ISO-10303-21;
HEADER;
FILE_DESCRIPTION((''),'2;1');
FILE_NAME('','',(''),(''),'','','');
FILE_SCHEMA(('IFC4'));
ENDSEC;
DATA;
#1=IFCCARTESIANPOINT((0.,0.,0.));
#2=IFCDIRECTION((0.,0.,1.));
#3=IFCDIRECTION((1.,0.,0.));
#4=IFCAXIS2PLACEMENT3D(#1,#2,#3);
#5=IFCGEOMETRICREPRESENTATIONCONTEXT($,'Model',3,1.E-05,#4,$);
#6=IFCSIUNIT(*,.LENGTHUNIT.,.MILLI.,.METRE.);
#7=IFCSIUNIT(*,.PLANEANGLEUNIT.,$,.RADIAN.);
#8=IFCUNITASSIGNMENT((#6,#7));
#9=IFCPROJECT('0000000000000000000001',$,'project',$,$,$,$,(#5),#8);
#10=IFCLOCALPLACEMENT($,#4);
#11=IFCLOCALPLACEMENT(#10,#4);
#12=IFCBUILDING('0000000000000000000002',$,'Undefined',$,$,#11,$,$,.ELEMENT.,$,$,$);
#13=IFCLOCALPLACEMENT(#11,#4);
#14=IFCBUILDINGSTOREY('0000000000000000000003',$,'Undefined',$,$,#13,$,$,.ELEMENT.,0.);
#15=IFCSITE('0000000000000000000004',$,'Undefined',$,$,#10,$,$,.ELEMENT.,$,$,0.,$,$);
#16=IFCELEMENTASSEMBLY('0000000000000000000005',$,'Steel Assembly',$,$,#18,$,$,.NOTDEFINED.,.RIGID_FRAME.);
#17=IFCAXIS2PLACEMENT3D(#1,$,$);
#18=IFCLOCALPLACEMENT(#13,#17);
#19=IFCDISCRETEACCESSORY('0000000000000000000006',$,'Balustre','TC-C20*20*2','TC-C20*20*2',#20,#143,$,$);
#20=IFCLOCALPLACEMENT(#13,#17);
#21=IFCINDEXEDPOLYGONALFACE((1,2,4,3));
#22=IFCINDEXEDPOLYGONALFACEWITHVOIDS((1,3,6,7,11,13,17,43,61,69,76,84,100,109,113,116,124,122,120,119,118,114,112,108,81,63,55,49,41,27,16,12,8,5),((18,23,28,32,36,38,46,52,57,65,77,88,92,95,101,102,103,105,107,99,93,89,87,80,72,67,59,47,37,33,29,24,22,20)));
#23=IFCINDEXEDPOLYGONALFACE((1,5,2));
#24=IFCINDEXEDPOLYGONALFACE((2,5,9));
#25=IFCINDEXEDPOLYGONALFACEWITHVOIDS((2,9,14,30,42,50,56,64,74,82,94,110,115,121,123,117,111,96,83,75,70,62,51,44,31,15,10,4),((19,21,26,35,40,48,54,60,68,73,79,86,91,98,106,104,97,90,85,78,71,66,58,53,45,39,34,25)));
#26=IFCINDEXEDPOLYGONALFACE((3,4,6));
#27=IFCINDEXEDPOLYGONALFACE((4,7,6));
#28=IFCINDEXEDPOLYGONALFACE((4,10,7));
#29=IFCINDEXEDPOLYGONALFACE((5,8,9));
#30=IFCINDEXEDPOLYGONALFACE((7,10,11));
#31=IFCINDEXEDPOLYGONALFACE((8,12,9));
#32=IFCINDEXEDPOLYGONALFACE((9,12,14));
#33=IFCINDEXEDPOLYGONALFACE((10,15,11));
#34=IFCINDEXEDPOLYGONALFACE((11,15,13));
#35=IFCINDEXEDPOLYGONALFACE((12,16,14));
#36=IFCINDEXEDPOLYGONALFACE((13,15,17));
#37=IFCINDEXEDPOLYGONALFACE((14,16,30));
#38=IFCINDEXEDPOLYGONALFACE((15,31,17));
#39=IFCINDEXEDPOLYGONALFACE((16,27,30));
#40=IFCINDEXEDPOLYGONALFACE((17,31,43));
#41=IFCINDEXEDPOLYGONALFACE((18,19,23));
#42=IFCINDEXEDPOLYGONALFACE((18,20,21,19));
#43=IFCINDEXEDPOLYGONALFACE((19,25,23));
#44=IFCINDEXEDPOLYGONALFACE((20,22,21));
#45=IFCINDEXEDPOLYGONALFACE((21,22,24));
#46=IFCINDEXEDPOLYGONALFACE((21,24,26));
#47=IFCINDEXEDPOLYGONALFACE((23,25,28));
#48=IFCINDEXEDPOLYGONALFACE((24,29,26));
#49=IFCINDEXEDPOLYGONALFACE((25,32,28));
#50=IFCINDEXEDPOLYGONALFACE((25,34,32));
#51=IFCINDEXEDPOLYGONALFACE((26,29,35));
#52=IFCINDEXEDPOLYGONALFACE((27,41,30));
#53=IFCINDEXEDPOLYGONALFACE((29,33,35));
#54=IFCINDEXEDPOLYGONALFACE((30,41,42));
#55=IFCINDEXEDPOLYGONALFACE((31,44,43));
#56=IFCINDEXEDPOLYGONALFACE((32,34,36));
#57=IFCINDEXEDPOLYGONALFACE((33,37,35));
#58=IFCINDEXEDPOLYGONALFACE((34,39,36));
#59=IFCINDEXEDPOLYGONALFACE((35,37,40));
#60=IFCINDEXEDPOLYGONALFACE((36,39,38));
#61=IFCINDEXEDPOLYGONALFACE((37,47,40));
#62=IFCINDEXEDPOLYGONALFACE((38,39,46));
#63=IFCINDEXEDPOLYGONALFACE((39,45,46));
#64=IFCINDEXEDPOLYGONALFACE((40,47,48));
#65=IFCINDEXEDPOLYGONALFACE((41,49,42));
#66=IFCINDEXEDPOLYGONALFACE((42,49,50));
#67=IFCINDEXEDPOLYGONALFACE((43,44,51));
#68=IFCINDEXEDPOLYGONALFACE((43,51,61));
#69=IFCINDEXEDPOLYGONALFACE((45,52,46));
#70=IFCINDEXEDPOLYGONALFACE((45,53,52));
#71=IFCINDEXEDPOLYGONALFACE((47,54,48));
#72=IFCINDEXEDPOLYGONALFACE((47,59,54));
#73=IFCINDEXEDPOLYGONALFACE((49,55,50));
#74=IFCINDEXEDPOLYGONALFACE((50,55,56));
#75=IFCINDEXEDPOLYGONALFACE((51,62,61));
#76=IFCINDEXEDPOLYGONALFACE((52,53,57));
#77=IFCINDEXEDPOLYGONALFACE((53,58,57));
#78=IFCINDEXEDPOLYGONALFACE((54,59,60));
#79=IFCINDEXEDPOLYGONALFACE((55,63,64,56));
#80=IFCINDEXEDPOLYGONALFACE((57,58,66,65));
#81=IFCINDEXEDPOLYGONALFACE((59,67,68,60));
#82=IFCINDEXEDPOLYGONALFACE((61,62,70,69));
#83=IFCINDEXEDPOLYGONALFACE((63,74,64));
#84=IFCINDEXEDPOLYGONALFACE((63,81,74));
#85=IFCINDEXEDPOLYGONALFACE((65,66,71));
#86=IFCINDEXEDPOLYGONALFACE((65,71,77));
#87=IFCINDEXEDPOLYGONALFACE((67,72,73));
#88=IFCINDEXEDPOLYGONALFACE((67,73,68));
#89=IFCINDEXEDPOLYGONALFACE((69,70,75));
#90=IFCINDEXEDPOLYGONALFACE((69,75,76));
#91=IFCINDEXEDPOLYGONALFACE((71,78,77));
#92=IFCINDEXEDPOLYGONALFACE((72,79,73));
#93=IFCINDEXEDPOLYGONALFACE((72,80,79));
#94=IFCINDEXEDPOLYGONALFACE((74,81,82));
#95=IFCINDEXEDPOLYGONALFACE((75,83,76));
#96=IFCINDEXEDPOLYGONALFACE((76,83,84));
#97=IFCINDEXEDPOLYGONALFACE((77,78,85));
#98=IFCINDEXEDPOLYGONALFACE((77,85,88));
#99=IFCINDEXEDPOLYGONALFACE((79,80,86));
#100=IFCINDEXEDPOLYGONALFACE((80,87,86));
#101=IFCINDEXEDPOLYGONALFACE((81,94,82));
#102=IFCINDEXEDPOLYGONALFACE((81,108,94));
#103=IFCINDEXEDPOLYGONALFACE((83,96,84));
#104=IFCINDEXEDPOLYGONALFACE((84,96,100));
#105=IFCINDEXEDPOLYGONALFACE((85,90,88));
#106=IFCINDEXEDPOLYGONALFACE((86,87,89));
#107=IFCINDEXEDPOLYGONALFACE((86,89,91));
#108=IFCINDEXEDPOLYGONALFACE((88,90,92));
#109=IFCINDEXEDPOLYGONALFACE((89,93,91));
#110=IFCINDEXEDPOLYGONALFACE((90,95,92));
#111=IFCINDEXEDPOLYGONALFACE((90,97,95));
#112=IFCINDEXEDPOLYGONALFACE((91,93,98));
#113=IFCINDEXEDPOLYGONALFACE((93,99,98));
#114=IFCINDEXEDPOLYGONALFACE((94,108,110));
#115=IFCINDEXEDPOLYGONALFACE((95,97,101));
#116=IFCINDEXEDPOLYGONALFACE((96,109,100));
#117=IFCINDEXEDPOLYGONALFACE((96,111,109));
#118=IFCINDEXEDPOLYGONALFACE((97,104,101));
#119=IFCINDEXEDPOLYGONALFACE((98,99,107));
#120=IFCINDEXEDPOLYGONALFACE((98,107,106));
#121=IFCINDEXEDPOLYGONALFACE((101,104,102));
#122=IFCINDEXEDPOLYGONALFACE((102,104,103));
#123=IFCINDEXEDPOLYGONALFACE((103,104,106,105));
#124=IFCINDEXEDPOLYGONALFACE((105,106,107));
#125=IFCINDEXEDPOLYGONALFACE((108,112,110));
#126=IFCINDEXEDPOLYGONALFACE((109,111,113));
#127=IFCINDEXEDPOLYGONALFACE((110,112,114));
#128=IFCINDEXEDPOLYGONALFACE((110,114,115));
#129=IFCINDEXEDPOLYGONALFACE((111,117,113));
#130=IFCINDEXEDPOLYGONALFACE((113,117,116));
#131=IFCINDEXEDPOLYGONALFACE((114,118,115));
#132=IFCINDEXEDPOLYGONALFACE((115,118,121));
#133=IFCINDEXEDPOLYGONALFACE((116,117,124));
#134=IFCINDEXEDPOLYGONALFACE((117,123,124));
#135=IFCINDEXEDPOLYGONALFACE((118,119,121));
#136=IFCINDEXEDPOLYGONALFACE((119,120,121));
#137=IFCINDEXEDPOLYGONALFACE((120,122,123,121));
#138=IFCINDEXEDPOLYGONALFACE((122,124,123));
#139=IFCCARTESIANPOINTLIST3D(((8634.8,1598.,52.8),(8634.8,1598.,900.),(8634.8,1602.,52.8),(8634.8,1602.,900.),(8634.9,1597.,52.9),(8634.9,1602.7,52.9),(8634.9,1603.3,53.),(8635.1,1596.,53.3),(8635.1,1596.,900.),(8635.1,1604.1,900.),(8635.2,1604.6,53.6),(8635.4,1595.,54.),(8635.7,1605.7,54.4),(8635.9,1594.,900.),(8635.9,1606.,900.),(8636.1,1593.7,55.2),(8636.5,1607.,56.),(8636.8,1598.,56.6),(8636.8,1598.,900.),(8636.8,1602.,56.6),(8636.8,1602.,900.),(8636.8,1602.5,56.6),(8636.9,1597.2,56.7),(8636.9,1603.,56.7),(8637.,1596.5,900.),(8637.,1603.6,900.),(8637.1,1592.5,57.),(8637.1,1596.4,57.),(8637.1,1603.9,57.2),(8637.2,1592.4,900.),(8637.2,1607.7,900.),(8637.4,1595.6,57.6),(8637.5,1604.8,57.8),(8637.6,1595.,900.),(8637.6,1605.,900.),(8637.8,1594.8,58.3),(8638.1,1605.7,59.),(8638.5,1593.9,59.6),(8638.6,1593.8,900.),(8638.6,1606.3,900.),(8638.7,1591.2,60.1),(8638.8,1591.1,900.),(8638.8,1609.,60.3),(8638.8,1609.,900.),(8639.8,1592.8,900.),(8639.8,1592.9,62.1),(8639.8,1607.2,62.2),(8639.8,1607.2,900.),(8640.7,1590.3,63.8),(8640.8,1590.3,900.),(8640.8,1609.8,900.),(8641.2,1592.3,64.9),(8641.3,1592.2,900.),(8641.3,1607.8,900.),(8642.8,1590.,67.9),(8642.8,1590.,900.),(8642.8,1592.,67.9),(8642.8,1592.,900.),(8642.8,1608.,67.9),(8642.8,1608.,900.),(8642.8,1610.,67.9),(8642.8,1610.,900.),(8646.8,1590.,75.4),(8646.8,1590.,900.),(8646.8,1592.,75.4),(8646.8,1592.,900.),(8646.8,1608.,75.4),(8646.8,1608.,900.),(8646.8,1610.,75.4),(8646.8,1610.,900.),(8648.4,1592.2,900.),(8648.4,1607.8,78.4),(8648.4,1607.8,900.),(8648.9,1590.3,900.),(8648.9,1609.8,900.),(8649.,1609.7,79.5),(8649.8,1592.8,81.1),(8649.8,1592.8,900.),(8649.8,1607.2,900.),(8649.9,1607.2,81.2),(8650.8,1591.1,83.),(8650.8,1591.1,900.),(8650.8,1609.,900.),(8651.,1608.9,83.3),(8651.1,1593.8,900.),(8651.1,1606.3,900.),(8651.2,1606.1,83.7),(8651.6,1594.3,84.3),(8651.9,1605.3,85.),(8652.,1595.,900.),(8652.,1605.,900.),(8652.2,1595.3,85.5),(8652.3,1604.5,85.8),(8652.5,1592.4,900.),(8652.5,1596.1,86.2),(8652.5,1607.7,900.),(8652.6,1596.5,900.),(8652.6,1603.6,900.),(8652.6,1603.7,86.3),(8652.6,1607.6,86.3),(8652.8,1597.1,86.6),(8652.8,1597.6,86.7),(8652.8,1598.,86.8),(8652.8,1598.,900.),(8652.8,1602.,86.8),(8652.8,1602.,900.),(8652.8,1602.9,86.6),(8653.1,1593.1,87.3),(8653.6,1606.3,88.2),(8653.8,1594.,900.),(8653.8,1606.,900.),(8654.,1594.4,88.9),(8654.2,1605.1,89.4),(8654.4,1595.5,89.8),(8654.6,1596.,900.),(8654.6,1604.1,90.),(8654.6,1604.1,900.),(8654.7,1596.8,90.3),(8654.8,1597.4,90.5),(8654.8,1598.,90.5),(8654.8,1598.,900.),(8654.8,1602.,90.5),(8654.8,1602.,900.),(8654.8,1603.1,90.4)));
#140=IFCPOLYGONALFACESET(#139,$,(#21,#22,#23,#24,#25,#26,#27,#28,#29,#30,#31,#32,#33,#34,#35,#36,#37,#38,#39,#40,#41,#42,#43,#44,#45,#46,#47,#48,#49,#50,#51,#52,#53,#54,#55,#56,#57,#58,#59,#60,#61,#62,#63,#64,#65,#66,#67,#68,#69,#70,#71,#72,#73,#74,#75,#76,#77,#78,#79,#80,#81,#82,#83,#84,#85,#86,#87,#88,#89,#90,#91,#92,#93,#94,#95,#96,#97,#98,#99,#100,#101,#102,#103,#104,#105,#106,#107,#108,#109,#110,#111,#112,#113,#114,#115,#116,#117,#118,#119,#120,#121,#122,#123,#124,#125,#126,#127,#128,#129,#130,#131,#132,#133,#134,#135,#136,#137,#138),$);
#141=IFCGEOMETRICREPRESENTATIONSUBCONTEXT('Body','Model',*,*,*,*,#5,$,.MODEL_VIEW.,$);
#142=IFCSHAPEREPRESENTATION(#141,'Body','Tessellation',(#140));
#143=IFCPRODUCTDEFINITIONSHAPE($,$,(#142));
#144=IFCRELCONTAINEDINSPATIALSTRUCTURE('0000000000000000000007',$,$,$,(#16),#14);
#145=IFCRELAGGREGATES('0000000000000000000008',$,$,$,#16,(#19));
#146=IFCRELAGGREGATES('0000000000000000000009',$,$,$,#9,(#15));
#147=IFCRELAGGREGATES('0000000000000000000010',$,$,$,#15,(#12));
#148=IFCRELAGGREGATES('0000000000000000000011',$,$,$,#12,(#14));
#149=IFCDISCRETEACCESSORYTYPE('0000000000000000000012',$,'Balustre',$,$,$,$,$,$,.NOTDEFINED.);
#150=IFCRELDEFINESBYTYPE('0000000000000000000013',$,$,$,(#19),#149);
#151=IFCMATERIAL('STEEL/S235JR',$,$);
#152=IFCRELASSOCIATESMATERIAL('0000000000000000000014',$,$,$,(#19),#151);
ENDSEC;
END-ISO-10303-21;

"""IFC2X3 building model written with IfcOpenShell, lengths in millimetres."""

from ifc_helpers import new_model, si_unit, frame, origin_with_axes, origin_2d_with_axis, place, context, subcontext, project, spatial, hollow_rectangle, extrude, clip, halfspace, material, type_object, element, aggregate, save


model = new_model("IFC2X3")

# Units and contexts
model_context = context("Model", 3, precision=1e-05, world=origin_with_axes())
body_context = subcontext(model_context, "Body", "Model", "MODEL_VIEW")
ifc_project = project(units=[si_unit("LENGTHUNIT", "METRE", prefix="MILLI"), si_unit("PLANEANGLEUNIT", "RADIAN")], contexts=[model_context])

# Site, building, storey
site_placement = place(None, origin_with_axes())
site = spatial("IfcSite", under=ifc_project, at=site_placement, Name="Undefined", CompositionType="ELEMENT", RefElevation=0.0)
building_placement = place(site_placement, origin_with_axes())
building = spatial("IfcBuilding", under=site, at=building_placement, Name="Undefined", CompositionType="ELEMENT")
storey_placement = place(building_placement, origin_with_axes())
storey = spatial("IfcBuildingStorey", under=building, at=storey_placement, Name="Undefined", CompositionType="ELEMENT", Elevation=0.0)

# Shared definitions
ifc_material = material(Name="STEEL/S235JR")

# Element assembly, discrete accessory
discrete_accessory_type_1 = type_object("IfcDiscreteAccessoryType", Name="Balustre")
assembly_1_placement = place(storey_placement, origin_with_axes())
assembly_1 = element("IfcElementAssembly", 1, at=assembly_1_placement, inside=storey, Name="Steel Assembly", AssemblyPlace="NOTDEFINED", PredefinedType="RIGID_FRAME")
discrete_accessory_1_placement = place(assembly_1_placement, frame((8644.8, 1600.0, 900.0), z_axis=(-0.000011, 1.0, 0.0), x_axis=(0.0, 0.0, -1.0)))
discrete_accessory_1 = element("IfcDiscreteAccessory", 2, at=discrete_accessory_1_placement, type_object=discrete_accessory_type_1, material=ifc_material, Name="Balustre", Description="TC-C20*20*2", ObjectType="TC-C20*20*2", context=body_context, shape_type="Clipping", body=[
    clip(extrude(hollow_rectangle(XDim=20.0, YDim=20.0, WallThickness=2.0, InnerFilletRadius=6.0, OuterFilletRadius=8.0, at=origin_2d_with_axis()), frame((847.4, 0.0, 0.0), z_axis=(-1.0, 0.0, 0.0), x_axis=(0.0, -1.0, 0.0)), (0.0, 0.0, 1.0), 847.4), halfspace(frame((855.2, 14.2, 0.0), z_axis=(-0.46842, 0.883506, 0.000005), x_axis=(0.0, -0.000005, 1.0)), True)),
])

aggregate(assembly_1, [discrete_accessory_1])

save(model, "model.ifc")
